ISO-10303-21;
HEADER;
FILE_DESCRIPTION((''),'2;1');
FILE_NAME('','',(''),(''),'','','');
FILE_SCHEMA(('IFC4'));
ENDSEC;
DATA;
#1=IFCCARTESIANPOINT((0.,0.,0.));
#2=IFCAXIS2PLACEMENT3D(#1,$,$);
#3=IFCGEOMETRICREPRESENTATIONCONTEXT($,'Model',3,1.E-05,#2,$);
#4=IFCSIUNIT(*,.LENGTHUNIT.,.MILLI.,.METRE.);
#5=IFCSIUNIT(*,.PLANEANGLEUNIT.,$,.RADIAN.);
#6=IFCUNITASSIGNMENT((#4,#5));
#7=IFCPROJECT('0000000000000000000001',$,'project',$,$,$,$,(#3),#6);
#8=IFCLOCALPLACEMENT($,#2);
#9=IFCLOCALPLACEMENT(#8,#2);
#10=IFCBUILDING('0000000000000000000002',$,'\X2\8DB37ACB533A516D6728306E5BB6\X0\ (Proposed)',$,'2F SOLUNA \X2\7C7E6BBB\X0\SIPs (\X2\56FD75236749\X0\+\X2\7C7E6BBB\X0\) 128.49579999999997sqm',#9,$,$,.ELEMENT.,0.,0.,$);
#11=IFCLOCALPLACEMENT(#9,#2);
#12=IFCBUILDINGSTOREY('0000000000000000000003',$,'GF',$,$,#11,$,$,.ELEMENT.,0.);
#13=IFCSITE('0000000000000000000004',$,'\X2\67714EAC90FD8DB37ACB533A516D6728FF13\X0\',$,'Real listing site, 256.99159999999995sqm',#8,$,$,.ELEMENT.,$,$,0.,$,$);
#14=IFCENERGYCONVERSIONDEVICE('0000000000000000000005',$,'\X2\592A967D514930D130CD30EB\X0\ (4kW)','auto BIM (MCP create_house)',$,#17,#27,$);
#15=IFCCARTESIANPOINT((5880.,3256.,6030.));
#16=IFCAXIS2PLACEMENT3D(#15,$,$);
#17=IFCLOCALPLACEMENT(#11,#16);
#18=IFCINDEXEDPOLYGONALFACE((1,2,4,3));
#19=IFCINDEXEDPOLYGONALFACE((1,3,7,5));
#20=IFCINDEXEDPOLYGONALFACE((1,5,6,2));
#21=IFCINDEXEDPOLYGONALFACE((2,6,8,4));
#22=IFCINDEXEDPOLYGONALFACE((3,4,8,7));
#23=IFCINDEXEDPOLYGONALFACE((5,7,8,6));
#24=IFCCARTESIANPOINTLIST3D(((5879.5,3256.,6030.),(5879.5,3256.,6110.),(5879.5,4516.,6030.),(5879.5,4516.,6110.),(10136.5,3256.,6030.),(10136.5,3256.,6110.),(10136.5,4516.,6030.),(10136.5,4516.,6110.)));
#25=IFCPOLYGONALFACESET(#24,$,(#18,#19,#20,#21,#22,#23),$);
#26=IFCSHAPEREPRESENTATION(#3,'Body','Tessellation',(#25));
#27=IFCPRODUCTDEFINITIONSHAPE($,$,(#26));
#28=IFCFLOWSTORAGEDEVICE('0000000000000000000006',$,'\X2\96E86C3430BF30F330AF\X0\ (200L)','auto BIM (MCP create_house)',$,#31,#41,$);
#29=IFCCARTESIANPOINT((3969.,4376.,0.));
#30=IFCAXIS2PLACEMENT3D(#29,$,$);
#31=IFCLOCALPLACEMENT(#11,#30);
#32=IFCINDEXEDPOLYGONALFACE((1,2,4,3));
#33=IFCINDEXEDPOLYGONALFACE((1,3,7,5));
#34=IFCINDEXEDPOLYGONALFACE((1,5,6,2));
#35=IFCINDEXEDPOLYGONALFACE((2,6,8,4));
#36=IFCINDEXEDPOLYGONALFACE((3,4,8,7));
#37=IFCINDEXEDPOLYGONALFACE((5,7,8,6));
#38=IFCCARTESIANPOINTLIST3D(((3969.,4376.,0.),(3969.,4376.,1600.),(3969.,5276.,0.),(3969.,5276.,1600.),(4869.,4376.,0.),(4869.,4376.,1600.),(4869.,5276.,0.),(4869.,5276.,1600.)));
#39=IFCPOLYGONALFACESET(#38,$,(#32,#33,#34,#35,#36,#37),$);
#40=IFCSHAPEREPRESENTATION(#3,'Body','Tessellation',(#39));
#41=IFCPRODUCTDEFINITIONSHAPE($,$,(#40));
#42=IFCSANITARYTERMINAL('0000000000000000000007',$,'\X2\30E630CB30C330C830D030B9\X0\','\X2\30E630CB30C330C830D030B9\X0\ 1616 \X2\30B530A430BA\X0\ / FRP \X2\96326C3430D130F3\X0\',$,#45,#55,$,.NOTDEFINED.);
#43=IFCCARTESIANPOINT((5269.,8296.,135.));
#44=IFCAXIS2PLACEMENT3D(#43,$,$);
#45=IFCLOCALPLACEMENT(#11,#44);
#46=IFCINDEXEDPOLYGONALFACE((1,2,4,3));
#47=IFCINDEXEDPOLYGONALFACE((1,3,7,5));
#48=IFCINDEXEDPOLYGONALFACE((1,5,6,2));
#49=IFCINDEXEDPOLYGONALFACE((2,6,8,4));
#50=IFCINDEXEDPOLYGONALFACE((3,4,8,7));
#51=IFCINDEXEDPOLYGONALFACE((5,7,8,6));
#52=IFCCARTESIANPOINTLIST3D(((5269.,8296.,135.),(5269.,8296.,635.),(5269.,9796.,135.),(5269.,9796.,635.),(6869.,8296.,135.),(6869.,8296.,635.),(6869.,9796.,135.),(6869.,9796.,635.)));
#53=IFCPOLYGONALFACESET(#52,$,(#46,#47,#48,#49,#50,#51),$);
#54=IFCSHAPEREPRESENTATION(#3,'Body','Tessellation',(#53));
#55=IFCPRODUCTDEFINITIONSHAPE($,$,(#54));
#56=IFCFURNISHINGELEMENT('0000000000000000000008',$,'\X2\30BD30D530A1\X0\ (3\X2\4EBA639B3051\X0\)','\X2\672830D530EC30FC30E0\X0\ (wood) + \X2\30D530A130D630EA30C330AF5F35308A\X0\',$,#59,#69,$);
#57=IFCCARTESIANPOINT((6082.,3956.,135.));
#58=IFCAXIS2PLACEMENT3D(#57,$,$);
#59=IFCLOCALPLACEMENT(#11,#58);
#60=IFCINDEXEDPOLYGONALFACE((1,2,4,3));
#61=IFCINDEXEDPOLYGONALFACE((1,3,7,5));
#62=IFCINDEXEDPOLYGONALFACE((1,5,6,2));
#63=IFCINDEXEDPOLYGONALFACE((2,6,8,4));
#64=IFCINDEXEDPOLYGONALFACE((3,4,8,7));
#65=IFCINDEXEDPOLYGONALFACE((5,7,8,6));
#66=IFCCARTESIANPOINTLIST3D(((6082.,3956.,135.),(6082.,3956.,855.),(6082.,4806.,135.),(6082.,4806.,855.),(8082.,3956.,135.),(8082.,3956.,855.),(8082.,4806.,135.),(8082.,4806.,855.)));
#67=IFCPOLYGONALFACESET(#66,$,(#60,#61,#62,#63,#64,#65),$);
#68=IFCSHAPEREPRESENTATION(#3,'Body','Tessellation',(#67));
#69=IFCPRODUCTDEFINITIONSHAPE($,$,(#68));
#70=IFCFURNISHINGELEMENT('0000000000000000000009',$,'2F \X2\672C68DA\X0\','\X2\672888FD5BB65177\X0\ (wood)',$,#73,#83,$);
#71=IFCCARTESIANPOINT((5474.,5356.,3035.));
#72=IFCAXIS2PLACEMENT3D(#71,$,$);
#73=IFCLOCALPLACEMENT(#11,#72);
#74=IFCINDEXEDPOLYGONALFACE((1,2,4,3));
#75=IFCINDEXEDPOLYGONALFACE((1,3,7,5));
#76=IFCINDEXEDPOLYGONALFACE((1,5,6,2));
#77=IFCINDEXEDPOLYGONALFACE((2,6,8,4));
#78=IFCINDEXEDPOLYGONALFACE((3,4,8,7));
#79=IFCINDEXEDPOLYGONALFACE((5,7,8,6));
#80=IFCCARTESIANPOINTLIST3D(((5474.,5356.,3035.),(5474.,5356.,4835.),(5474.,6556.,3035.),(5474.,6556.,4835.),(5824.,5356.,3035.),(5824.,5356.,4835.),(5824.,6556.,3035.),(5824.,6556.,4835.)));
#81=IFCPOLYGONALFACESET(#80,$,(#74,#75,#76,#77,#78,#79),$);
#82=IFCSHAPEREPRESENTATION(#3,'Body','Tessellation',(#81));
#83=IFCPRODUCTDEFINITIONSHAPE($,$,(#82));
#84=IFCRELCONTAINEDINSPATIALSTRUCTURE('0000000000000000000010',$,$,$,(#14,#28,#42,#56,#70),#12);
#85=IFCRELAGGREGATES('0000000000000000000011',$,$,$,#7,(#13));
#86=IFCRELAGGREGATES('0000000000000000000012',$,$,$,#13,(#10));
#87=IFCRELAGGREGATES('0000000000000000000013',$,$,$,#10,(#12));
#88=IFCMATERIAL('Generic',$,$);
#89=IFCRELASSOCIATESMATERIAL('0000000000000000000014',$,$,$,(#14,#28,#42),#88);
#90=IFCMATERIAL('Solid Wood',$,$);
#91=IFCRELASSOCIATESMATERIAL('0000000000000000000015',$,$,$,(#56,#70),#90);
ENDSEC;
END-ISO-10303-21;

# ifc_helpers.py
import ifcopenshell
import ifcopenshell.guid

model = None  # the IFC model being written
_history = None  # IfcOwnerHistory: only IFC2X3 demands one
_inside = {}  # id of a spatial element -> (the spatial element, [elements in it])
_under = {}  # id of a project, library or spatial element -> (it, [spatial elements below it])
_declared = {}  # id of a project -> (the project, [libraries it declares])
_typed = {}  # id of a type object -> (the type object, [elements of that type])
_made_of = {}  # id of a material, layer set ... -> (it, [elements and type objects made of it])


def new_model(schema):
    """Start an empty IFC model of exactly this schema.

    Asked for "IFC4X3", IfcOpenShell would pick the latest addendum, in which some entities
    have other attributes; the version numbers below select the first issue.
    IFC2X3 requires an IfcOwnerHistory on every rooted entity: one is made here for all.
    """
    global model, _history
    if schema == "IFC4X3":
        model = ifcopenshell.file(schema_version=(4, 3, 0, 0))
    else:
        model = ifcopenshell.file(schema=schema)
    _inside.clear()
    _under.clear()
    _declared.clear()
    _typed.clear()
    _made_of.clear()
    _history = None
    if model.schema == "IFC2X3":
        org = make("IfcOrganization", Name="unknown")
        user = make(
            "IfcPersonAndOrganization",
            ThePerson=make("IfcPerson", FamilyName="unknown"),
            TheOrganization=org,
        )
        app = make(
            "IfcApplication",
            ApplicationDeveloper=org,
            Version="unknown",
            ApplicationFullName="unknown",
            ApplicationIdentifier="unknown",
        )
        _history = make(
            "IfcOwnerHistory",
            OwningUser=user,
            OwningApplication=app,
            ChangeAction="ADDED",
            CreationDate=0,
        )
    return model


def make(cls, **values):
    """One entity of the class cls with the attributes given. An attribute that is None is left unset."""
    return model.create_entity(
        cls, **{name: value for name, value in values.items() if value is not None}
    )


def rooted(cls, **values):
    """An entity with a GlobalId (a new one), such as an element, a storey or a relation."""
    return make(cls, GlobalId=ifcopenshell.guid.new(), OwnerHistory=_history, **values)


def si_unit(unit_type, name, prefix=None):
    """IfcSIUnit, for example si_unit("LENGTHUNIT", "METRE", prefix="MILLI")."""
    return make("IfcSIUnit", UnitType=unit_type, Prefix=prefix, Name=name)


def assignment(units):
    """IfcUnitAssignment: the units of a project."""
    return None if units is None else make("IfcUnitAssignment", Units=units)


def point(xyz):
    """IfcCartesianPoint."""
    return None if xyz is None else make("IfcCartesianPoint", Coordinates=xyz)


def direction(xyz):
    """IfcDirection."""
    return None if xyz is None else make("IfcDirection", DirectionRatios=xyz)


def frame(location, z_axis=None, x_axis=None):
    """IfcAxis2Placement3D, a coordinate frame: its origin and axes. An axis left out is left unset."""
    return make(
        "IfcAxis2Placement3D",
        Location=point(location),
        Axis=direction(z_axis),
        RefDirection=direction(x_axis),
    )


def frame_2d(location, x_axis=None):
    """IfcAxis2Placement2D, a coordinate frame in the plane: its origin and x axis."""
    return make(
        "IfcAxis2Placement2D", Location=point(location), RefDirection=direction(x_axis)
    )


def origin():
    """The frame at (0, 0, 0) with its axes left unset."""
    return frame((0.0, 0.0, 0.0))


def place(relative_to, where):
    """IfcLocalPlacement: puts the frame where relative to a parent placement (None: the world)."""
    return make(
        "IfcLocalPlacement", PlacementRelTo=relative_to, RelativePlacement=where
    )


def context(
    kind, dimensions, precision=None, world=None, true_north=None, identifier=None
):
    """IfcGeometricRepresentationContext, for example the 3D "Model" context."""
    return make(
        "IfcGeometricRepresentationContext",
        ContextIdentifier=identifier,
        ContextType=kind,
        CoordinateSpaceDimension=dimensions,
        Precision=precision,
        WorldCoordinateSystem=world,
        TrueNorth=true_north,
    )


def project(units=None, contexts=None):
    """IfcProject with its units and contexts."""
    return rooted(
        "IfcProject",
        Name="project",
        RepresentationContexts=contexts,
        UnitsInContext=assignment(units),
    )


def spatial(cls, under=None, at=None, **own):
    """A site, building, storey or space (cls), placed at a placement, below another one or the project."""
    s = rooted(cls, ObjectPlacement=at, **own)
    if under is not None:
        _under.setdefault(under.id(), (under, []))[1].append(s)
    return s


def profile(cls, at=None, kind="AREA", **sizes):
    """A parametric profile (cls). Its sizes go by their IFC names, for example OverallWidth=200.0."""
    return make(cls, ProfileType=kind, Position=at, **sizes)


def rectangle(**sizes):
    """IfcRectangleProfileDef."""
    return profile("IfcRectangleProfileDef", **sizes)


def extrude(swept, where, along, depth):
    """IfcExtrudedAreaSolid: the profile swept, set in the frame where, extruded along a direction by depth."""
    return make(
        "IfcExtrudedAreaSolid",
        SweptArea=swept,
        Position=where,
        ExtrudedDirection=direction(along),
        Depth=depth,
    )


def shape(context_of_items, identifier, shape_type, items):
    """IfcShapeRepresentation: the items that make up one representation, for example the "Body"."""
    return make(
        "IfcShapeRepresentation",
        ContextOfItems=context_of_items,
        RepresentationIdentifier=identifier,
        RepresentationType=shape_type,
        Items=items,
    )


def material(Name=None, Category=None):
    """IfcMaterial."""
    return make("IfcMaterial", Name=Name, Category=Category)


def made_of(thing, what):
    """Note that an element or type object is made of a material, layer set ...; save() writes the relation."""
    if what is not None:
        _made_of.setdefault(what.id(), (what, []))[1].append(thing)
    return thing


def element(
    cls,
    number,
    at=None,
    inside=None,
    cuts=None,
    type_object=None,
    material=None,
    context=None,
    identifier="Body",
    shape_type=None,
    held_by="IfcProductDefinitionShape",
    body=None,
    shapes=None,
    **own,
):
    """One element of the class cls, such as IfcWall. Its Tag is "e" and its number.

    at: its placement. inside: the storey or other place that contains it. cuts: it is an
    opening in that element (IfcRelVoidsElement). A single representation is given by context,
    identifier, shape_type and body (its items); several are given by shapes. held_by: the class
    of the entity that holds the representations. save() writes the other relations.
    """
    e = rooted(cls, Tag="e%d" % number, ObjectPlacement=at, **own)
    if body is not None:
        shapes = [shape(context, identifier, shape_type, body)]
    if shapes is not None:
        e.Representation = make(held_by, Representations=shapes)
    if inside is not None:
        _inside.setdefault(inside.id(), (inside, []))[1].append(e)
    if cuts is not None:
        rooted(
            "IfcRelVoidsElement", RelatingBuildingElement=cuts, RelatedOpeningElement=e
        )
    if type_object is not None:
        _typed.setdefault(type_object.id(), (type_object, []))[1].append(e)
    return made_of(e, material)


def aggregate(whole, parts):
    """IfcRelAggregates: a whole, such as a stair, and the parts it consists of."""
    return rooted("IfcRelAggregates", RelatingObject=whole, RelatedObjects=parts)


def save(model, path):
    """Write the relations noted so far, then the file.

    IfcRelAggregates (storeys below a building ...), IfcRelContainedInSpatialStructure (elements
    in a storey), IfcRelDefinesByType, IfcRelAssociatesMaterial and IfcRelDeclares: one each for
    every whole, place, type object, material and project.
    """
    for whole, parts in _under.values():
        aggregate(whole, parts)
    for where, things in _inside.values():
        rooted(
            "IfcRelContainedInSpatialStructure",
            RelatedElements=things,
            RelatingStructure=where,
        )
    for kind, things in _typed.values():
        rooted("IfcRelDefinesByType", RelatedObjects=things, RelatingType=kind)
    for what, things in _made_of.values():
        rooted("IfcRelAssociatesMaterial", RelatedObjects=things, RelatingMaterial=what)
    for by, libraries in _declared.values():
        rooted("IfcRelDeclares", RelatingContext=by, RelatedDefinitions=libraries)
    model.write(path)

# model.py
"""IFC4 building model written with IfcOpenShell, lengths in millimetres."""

from ifc_helpers import new_model, si_unit, frame, frame_2d, origin, place, context, project, spatial, rectangle, extrude, material, element, save


model = new_model("IFC4")

# Units and contexts
model_context = context("Model", 3, precision=1e-05, world=origin())
ifc_project = project(units=[si_unit("LENGTHUNIT", "METRE", prefix="MILLI"), si_unit("PLANEANGLEUNIT", "RADIAN")], contexts=[model_context])

# Site, building, storey
site_placement = place(None, origin())
site = spatial("IfcSite", under=ifc_project, at=site_placement, Name="東京都足立区六木３", ObjectType="Real listing site, 256.99159999999995sqm", CompositionType="ELEMENT", RefElevation=0.0)
building_placement = place(site_placement, origin())
building = spatial("IfcBuilding", under=site, at=building_placement, Name="足立区六木の家 (Proposed)", ObjectType="2F SOLUNA 籾殻SIPs (国産杉+籾殻) 128.49579999999997sqm", CompositionType="ELEMENT", ElevationOfRefHeight=0.0, ElevationOfTerrain=0.0)
storey_placement = place(building_placement, origin())
storey = spatial("IfcBuildingStorey", under=building, at=storey_placement, Name="GF", CompositionType="ELEMENT", Elevation=0.0)

# Shared definitions
ifc_material_1 = material(Name="Solid Wood")

# Energy conversion device
ifc_material_2 = material(Name="Generic")
energy_conversion_device_placement = place(storey_placement, frame((5880.0, 3256.0, 6030.0)))
element("IfcEnergyConversionDevice", 1, at=energy_conversion_device_placement, inside=storey, material=ifc_material_2, Name="太陽光パネル (4kW)", Description="auto BIM (MCP create_house)", context=model_context, shape_type="SweptSolid", body=[
    extrude(rectangle(XDim=4257.0, YDim=1260.0, at=frame_2d((2128.0, 630.0))), frame((5880.0, 3256.0, 6030.0)), (0.0, 0.0, 1.0), 80.0),
])

# Flow storage device
flow_storage_device_placement = place(storey_placement, frame((3969.0, 4376.0, 0.0)))
element("IfcFlowStorageDevice", 2, at=flow_storage_device_placement, inside=storey, material=ifc_material_2, Name="雨水タンク (200L)", Description="auto BIM (MCP create_house)", context=model_context, shape_type="SweptSolid", body=[
    extrude(rectangle(XDim=900.0, YDim=900.0, at=frame_2d((450.0, 450.0))), frame((3969.0, 4376.0, 0.0)), (0.0, 0.0, 1.0), 1600.0),
])

# Sanitary terminal
sanitary_terminal_placement = place(storey_placement, frame((5269.0, 8296.0, 135.0)))
element("IfcSanitaryTerminal", 3, at=sanitary_terminal_placement, inside=storey, material=ifc_material_2, Name="ユニットバス", Description="ユニットバス 1616 サイズ / FRP 防水パン", PredefinedType="NOTDEFINED", context=model_context, shape_type="SweptSolid", body=[
    extrude(rectangle(XDim=1600.0, YDim=1500.0, at=frame_2d((800.0, 750.0))), frame((5269.0, 8296.0, 135.0)), (0.0, 0.0, 1.0), 500.0),
])

# Furnishing elements
furnishing_1_placement = place(storey_placement, frame((6082.0, 3956.0, 135.0)))
element("IfcFurnishingElement", 4, at=furnishing_1_placement, inside=storey, material=ifc_material_1, Name="ソファ (3人掛け)", Description="木フレーム (wood) + ファブリック張り", context=model_context, shape_type="SweptSolid", body=[
    extrude(rectangle(XDim=2000.0, YDim=850.0, at=frame_2d((1000.0, 425.0))), frame((6082.0, 3956.0, 135.0)), (0.0, 0.0, 1.0), 720.0),
])
furnishing_2_placement = place(storey_placement, frame((5474.0, 5356.0, 3035.0)))
element("IfcFurnishingElement", 5, at=furnishing_2_placement, inside=storey, material=ifc_material_1, Name="2F 本棚", Description="木製家具 (wood)", context=model_context, shape_type="SweptSolid", body=[
    extrude(rectangle(XDim=350.0, YDim=1200.0, at=frame_2d((175.0, 600.0))), frame((5474.0, 5356.0, 3035.0)), (0.0, 0.0, 1.0), 1800.0),
])

save(model, "model.ifc")
